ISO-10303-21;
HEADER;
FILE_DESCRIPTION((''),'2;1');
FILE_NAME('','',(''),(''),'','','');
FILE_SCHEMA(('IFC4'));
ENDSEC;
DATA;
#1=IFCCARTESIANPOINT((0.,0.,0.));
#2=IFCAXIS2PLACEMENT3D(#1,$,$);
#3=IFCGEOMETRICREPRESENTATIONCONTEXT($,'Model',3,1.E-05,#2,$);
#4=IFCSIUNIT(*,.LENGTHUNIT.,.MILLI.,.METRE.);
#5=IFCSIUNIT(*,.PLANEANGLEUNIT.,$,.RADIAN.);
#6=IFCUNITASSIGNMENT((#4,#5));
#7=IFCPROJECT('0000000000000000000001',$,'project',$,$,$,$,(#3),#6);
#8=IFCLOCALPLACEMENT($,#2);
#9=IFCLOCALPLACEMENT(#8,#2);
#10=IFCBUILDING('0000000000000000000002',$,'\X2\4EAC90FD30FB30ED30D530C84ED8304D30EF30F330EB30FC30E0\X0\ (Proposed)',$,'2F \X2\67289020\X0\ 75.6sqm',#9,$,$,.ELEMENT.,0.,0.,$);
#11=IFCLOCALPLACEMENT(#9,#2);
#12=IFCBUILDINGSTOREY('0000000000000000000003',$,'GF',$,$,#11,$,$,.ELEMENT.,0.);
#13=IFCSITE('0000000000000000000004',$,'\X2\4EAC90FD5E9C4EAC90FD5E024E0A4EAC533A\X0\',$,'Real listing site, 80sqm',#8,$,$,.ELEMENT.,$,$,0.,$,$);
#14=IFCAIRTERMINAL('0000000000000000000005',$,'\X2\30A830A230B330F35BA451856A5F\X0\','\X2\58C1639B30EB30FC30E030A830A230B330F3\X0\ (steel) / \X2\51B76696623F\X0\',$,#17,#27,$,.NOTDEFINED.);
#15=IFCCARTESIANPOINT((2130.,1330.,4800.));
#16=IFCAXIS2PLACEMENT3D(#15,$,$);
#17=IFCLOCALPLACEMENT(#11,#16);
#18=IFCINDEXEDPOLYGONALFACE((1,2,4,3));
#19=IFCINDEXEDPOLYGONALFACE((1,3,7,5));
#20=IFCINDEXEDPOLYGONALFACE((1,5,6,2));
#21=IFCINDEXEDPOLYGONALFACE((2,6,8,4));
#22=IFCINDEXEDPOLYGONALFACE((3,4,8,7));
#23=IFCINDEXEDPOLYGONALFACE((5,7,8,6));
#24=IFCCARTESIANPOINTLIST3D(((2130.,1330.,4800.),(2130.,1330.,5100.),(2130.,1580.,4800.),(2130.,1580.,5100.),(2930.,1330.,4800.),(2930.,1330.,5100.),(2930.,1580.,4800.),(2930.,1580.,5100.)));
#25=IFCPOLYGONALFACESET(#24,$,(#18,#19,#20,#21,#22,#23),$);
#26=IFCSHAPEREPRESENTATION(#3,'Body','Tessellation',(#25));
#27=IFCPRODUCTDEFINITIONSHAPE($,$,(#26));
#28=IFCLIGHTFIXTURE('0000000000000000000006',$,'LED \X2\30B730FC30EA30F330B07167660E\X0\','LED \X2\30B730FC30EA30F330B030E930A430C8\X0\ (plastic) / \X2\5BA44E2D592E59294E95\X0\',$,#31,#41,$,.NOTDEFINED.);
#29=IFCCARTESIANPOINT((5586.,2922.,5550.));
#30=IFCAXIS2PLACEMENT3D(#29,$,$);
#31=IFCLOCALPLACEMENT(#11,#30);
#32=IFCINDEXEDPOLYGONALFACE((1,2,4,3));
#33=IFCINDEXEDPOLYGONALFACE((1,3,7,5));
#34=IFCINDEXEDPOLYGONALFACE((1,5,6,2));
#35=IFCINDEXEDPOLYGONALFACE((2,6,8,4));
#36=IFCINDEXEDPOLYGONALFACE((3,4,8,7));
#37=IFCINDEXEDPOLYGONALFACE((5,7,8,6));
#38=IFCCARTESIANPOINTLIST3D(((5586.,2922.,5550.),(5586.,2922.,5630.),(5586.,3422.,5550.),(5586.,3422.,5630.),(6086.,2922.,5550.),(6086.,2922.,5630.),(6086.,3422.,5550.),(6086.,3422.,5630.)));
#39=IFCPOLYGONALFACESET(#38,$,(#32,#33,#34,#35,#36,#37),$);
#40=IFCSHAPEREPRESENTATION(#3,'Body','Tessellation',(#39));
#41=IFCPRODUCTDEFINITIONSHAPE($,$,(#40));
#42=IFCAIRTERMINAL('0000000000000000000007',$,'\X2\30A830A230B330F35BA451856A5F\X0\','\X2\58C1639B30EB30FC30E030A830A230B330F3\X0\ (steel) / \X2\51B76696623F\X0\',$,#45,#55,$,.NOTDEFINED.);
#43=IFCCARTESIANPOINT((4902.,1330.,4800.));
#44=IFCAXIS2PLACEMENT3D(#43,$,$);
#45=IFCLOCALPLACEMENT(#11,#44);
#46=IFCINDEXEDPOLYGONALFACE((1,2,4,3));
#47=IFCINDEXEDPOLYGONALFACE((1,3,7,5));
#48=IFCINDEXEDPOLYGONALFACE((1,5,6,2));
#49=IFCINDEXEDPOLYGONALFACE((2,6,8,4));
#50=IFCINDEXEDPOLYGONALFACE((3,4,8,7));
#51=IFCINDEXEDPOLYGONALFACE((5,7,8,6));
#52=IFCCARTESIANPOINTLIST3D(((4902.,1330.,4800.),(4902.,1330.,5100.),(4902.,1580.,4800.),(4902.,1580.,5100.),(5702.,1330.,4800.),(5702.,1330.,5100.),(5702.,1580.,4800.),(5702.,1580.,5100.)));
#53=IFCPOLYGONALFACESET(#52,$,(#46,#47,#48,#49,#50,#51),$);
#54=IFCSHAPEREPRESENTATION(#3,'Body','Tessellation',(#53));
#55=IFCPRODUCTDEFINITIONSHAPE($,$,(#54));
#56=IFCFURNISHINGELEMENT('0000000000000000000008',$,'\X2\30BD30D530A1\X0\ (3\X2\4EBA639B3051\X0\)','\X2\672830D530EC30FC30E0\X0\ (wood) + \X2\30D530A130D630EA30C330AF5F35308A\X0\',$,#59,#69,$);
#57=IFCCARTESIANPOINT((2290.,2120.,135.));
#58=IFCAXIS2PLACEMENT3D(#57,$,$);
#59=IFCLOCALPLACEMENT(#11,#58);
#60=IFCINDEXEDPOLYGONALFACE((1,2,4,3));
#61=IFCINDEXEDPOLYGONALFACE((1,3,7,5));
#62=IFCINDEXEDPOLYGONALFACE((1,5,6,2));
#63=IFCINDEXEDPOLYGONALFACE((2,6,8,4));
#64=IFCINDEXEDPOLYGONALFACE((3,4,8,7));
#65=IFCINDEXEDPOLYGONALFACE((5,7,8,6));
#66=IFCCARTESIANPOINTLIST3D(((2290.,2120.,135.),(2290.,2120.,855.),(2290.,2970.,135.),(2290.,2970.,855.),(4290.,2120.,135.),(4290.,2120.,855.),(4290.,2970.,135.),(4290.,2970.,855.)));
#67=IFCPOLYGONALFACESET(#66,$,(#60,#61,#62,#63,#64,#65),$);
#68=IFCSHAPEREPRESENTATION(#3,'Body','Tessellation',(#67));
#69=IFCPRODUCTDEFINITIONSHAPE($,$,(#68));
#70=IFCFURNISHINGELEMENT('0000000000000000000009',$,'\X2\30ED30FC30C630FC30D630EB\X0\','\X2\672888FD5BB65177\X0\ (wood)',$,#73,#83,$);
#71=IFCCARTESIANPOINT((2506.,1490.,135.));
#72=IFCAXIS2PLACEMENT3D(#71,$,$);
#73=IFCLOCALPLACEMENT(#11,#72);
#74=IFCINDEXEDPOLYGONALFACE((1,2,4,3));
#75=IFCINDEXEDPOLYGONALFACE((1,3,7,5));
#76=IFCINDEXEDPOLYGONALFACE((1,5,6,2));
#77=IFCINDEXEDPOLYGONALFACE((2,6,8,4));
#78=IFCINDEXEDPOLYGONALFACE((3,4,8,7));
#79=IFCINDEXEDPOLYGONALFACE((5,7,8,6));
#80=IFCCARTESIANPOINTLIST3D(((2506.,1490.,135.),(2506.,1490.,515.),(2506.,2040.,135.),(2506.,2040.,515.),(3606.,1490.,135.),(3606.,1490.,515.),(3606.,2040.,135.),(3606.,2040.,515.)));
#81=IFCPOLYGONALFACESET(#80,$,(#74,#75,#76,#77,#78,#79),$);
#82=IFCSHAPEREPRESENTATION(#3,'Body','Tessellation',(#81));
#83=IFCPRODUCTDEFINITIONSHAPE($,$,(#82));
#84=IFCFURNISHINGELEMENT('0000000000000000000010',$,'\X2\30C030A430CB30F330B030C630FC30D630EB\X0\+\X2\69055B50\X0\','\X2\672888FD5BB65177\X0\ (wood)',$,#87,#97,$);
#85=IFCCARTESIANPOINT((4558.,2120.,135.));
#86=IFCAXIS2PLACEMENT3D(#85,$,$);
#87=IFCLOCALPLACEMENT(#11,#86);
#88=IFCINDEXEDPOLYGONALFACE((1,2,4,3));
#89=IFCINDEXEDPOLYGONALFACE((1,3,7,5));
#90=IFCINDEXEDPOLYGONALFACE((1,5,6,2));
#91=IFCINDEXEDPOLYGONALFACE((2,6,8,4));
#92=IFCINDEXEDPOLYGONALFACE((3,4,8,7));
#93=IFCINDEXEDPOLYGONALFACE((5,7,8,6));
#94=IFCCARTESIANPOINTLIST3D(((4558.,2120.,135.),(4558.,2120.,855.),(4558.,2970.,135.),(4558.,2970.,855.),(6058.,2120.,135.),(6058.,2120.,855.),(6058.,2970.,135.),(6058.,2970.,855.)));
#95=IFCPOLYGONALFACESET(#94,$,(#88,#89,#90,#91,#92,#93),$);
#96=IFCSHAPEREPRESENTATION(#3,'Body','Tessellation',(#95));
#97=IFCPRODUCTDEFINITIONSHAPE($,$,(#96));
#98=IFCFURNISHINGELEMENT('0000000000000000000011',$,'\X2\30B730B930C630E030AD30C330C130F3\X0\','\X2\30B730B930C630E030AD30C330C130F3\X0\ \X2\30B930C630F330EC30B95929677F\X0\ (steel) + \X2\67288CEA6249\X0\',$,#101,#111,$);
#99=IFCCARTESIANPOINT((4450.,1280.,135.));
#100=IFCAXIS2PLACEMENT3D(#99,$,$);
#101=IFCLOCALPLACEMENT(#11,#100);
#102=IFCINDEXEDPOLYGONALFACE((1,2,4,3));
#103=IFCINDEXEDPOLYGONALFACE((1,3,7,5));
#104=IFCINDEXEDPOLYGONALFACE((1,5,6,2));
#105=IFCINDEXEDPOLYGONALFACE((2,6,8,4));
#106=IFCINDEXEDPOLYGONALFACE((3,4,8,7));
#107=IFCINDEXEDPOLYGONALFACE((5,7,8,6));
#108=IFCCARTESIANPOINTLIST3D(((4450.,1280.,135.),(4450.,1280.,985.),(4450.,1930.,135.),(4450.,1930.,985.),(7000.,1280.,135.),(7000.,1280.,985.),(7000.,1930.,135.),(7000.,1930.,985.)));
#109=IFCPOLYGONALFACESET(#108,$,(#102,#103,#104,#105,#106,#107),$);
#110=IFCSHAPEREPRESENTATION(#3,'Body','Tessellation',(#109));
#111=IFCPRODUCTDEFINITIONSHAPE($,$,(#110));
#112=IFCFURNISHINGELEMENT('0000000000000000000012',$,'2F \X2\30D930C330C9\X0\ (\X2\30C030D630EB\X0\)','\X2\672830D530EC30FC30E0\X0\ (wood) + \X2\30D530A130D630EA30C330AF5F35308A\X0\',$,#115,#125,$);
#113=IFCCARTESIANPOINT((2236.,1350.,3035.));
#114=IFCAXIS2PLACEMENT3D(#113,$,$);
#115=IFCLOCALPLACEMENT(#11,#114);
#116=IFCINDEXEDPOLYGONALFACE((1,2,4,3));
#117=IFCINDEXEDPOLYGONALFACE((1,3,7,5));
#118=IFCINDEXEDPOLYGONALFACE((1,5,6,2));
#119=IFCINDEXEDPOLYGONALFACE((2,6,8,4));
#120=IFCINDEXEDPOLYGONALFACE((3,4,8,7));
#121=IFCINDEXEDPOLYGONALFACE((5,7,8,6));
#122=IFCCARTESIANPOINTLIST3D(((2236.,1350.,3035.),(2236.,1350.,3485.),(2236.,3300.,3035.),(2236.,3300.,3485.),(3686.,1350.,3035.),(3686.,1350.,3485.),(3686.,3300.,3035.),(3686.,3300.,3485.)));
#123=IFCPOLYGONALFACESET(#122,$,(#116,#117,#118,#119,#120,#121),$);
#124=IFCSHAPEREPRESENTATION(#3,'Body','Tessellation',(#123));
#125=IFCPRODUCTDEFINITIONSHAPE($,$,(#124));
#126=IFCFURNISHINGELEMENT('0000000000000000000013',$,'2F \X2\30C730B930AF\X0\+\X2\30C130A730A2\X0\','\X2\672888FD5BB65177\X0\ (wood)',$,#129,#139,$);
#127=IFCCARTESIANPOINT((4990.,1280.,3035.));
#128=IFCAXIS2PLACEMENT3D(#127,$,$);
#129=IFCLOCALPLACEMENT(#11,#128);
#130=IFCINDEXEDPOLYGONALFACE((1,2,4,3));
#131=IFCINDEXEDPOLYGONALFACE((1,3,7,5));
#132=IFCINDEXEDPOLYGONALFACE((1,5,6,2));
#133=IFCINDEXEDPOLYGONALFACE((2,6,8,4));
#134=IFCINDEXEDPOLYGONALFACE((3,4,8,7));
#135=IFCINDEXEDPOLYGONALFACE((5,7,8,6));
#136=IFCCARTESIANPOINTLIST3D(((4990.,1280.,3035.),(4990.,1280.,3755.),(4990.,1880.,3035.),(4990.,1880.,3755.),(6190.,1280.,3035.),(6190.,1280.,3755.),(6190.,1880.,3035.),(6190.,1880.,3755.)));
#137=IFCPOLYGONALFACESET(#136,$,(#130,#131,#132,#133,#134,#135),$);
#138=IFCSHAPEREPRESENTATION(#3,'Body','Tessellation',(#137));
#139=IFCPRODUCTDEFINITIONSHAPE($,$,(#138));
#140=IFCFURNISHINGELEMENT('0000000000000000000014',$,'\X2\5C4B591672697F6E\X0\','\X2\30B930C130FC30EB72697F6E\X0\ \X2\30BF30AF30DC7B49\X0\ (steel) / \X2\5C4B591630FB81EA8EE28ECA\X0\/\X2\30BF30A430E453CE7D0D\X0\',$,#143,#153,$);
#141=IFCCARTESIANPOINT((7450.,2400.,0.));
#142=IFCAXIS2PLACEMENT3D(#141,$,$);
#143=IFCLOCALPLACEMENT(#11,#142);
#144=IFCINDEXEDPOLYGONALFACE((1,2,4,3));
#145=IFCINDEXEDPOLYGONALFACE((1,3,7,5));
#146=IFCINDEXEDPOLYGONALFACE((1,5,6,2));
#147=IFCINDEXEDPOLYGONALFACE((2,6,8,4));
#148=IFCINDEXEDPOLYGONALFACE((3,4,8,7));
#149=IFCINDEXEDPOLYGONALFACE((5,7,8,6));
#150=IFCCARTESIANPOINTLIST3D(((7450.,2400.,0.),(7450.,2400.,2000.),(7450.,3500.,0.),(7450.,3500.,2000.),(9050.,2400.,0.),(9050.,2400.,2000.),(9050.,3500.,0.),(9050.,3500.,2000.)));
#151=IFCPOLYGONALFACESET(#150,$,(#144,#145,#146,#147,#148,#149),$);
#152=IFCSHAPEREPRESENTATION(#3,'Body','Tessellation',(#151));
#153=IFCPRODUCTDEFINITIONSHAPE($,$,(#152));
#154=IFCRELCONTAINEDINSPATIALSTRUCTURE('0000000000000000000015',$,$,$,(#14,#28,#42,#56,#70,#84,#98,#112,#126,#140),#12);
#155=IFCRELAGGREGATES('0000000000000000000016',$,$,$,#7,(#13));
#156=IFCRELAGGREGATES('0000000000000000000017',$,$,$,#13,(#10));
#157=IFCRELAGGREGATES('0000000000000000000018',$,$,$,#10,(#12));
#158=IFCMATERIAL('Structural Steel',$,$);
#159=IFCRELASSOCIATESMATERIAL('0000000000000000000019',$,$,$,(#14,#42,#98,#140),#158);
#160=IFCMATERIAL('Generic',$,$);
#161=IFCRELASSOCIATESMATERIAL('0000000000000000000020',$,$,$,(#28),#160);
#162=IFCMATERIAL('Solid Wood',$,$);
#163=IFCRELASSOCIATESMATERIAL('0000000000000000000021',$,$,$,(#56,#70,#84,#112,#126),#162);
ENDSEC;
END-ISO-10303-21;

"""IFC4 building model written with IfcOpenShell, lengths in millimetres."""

from ifc_helpers import new_model, si_unit, frame, frame_2d, origin, place, context, project, spatial, rectangle, extrude, material, element, save


model = new_model("IFC4")

# Units and contexts
model_context = context("Model", 3, precision=1e-05, world=origin())
ifc_project = project(units=[si_unit("LENGTHUNIT", "METRE", prefix="MILLI"), si_unit("PLANEANGLEUNIT", "RADIAN")], contexts=[model_context])

# Site, building, storey
site_placement = place(None, origin())
site = spatial("IfcSite", under=ifc_project, at=site_placement, Name="京都府京都市上京区", ObjectType="Real listing site, 80sqm", CompositionType="ELEMENT", RefElevation=0.0)
building_placement = place(site_placement, origin())
building = spatial("IfcBuilding", under=site, at=building_placement, Name="京都・ロフト付きワンルーム (Proposed)", ObjectType="2F 木造 75.6sqm", CompositionType="ELEMENT", ElevationOfRefHeight=0.0, ElevationOfTerrain=0.0)
storey_placement = place(building_placement, origin())
storey = spatial("IfcBuildingStorey", under=building, at=storey_placement, Name="GF", CompositionType="ELEMENT", Elevation=0.0)

# Shared definitions
ifc_material_1 = material(Name="Solid Wood")

# Shared definitions
ifc_material_2 = material(Name="Generic")

# Shared definitions
ifc_material_3 = material(Name="Structural Steel")

# Air terminal
air_terminal_1_placement = place(storey_placement, frame((2130.0, 1330.0, 4800.0)))
element("IfcAirTerminal", 1, at=air_terminal_1_placement, inside=storey, material=ifc_material_3, Name="エアコン室内機", Description="壁掛ルームエアコン (steel) / 冷暖房", PredefinedType="NOTDEFINED", context=model_context, shape_type="SweptSolid", body=[
    extrude(rectangle(XDim=800.0, YDim=250.0, at=frame_2d((400.0, 125.0))), frame((2130.0, 1330.0, 4800.0)), (0.0, 0.0, 1.0), 300.0),
])

# Light fixture
light_fixture_placement = place(storey_placement, frame((5586.0, 2922.0, 5550.0)))
element("IfcLightFixture", 2, at=light_fixture_placement, inside=storey, material=ifc_material_2, Name="LED シーリング照明", Description="LED シーリングライト (plastic) / 室中央天井", PredefinedType="NOTDEFINED", context=model_context, shape_type="SweptSolid", body=[
    extrude(rectangle(XDim=500.0, YDim=500.0, at=frame_2d((250.0, 250.0))), frame((5586.0, 2922.0, 5550.0)), (0.0, 0.0, 1.0), 80.0),
])

# Air terminal
air_terminal_2_placement = place(storey_placement, frame((4902.0, 1330.0, 4800.0)))
element("IfcAirTerminal", 3, at=air_terminal_2_placement, inside=storey, material=ifc_material_3, Name="エアコン室内機", Description="壁掛ルームエアコン (steel) / 冷暖房", PredefinedType="NOTDEFINED", context=model_context, shape_type="SweptSolid", body=[
    extrude(rectangle(XDim=800.0, YDim=250.0, at=frame_2d((400.0, 125.0))), frame((4902.0, 1330.0, 4800.0)), (0.0, 0.0, 1.0), 300.0),
])

# Furnishing elements
furnishing_1_placement = place(storey_placement, frame((2290.0, 2120.0, 135.0)))
element("IfcFurnishingElement", 4, at=furnishing_1_placement, inside=storey, material=ifc_material_1, Name="ソファ (3人掛け)", Description="木フレーム (wood) + ファブリック張り", context=model_context, shape_type="SweptSolid", body=[
    extrude(rectangle(XDim=2000.0, YDim=850.0, at=frame_2d((1000.0, 425.0))), frame((2290.0, 2120.0, 135.0)), (0.0, 0.0, 1.0), 720.0),
])
furnishing_2_placement = place(storey_placement, frame((2506.0, 1490.0, 135.0)))
element("IfcFurnishingElement", 5, at=furnishing_2_placement, inside=storey, material=ifc_material_1, Name="ローテーブル", Description="木製家具 (wood)", context=model_context, shape_type="SweptSolid", body=[
    extrude(rectangle(XDim=1100.0, YDim=550.0, at=frame_2d((550.0, 275.0))), frame((2506.0, 1490.0, 135.0)), (0.0, 0.0, 1.0), 380.0),
])
furnishing_3_placement = place(storey_placement, frame((4558.0, 2120.0, 135.0)))
element("IfcFurnishingElement", 6, at=furnishing_3_placement, inside=storey, material=ifc_material_1, Name="ダイニングテーブル+椅子", Description="木製家具 (wood)", context=model_context, shape_type="SweptSolid", body=[
    extrude(rectangle(XDim=1500.0, YDim=850.0, at=frame_2d((750.0, 425.0))), frame((4558.0, 2120.0, 135.0)), (0.0, 0.0, 1.0), 720.0),
])
furnishing_4_placement = place(storey_placement, frame((4450.0, 1280.0, 135.0)))
element("IfcFurnishingElement", 7, at=furnishing_4_placement, inside=storey, material=ifc_material_3, Name="システムキッチン", Description="システムキッチン ステンレス天板 (steel) + 木質扉", context=model_context, shape_type="SweptSolid", body=[
    extrude(rectangle(XDim=2550.0, YDim=650.0, at=frame_2d((1275.0, 325.0))), frame((4450.0, 1280.0, 135.0)), (0.0, 0.0, 1.0), 850.0),
])
furnishing_5_placement = place(storey_placement, frame((2236.0, 1350.0, 3035.0)))
element("IfcFurnishingElement", 8, at=furnishing_5_placement, inside=storey, material=ifc_material_1, Name="2F ベッド (ダブル)", Description="木フレーム (wood) + ファブリック張り", context=model_context, shape_type="SweptSolid", body=[
    extrude(rectangle(XDim=1450.0, YDim=1950.0, at=frame_2d((725.0, 975.0))), frame((2236.0, 1350.0, 3035.0)), (0.0, 0.0, 1.0), 450.0),
])
furnishing_6_placement = place(storey_placement, frame((4990.0, 1280.0, 3035.0)))
element("IfcFurnishingElement", 9, at=furnishing_6_placement, inside=storey, material=ifc_material_1, Name="2F デスク+チェア", Description="木製家具 (wood)", context=model_context, shape_type="SweptSolid", body=[
    extrude(rectangle(XDim=1200.0, YDim=600.0, at=frame_2d((600.0, 300.0))), frame((4990.0, 1280.0, 3035.0)), (0.0, 0.0, 1.0), 720.0),
])
furnishing_7_placement = place(storey_placement, frame((7450.0, 2400.0, 0.0)))
element("IfcFurnishingElement", 10, at=furnishing_7_placement, inside=storey, material=ifc_material_3, Name="屋外物置", Description="スチール物置 タクボ等 (steel) / 屋外・自転車/タイヤ収納", context=model_context, shape_type="SweptSolid", body=[
    extrude(rectangle(XDim=1600.0, YDim=1100.0, at=frame_2d((800.0, 550.0))), frame((7450.0, 2400.0, 0.0)), (0.0, 0.0, 1.0), 2000.0),
])

save(model, "model.ifc")
